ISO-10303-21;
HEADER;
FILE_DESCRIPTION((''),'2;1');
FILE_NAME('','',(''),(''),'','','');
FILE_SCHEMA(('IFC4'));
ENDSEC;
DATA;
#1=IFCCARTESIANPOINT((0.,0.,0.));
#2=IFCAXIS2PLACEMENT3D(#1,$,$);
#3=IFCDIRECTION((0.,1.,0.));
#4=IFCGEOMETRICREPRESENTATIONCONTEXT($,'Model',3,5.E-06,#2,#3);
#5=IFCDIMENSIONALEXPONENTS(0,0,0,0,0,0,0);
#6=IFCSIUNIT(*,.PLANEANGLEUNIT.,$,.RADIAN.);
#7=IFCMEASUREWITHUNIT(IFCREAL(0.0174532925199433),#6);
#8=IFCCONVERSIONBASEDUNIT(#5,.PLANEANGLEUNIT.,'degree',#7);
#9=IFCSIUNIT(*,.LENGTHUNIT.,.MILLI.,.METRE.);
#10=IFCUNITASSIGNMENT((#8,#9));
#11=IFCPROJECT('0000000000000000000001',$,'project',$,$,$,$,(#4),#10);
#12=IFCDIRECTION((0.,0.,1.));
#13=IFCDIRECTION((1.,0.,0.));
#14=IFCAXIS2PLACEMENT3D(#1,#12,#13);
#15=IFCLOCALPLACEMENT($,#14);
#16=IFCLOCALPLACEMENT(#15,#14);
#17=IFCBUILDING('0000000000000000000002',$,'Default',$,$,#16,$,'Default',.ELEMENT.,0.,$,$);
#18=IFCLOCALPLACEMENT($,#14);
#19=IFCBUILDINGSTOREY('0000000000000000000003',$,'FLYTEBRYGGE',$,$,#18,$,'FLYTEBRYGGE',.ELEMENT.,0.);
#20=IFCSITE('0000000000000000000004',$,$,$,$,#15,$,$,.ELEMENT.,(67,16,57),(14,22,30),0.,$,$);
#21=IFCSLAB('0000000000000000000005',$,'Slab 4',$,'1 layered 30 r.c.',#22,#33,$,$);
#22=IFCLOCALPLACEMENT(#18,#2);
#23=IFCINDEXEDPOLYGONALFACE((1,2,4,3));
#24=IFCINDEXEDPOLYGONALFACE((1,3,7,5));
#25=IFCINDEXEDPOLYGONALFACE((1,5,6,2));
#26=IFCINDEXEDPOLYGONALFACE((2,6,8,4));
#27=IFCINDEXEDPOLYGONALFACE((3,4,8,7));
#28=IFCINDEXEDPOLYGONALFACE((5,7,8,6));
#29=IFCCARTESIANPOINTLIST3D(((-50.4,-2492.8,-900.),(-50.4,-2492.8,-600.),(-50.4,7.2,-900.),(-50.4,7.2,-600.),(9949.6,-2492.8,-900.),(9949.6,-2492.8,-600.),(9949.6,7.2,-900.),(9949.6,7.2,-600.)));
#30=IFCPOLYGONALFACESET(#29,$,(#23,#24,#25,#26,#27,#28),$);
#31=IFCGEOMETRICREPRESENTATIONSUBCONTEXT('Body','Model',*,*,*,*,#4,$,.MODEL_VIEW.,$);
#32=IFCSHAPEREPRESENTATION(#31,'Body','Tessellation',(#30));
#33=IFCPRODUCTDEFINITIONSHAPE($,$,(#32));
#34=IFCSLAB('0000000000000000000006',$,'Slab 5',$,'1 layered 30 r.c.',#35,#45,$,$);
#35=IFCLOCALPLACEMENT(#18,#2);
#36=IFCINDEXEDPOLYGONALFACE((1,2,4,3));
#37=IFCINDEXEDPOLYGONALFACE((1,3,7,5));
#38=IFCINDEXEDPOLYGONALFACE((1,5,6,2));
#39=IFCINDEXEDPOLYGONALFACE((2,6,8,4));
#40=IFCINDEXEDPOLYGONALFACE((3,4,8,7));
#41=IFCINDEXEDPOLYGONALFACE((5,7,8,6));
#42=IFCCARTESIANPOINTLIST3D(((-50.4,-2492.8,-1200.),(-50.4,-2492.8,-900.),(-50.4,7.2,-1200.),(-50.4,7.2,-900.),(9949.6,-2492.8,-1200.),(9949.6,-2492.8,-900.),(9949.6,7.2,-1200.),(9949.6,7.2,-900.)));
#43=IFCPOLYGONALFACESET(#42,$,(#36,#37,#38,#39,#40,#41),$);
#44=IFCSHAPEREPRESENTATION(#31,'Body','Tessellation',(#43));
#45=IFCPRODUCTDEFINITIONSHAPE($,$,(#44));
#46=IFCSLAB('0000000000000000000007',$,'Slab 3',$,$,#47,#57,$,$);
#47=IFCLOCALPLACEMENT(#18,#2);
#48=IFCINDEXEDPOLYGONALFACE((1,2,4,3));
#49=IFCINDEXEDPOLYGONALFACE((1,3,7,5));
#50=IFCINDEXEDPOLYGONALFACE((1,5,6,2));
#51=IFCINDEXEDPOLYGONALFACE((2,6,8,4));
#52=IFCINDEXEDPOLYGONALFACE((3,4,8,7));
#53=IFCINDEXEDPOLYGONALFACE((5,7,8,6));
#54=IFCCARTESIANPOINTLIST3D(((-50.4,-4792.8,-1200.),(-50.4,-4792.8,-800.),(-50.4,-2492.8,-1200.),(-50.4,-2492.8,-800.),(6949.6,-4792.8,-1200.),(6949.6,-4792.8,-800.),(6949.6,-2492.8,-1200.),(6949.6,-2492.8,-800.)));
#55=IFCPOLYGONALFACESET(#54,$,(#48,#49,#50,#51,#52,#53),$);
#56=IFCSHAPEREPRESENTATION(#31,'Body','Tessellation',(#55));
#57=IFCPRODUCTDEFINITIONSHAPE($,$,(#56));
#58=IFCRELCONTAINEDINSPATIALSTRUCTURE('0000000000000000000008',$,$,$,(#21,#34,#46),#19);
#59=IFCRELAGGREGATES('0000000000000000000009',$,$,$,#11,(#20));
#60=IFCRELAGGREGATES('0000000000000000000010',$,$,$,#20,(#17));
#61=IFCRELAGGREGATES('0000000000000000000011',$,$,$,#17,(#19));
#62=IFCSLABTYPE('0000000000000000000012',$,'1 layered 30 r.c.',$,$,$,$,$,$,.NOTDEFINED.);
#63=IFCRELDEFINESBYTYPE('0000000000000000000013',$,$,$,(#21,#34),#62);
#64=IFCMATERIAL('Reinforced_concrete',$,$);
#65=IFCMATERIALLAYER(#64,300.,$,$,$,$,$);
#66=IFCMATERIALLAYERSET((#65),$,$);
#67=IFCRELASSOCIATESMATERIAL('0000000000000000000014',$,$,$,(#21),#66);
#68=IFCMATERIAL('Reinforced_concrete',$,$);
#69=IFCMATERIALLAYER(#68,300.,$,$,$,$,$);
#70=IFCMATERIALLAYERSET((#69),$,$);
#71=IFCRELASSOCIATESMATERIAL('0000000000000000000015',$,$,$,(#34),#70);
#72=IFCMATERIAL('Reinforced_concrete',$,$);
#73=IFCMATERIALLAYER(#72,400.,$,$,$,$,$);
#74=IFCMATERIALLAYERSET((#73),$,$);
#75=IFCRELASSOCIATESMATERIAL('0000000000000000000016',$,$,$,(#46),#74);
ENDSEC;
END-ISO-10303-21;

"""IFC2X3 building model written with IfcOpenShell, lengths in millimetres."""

from ifc_helpers import new_model, entity, si_unit, converted_unit, direction, frame, origin, origin_with_axes, place, context, subcontext, project, spatial, polyline, outline, extrude, material, layer, layer_set, layer_usage, type_object, element, save


model = new_model("IFC2X3")

# Units and contexts
model_context = context("Model", 3, precision=5e-06, world=origin(), true_north=direction((0.0, 1.0, 0.0)))
body_context = subcontext(model_context, "Body", "Model", "MODEL_VIEW")
ifc_project = project(units=[converted_unit("PLANEANGLEUNIT", "degree", entity("IfcReal", 0.0174532925199433), si_unit("PLANEANGLEUNIT", "RADIAN"), dimensions=[0, 0, 0, 0, 0, 0, 0]), si_unit("LENGTHUNIT", "METRE", prefix="MILLI")], contexts=[model_context])

# Site, building, storey
site_placement = place(None, origin_with_axes())
site = spatial("IfcSite", under=ifc_project, at=site_placement, CompositionType="ELEMENT", RefLatitude=(67, 16, 57), RefLongitude=(14, 22, 30), RefElevation=0.0)
building_placement = place(site_placement, origin_with_axes())
building = spatial("IfcBuilding", under=site, at=building_placement, Name="Default", LongName="Default", CompositionType="ELEMENT", ElevationOfRefHeight=0.0)
storey_placement = place(None, origin_with_axes())
storey = spatial("IfcBuildingStorey", under=building, at=storey_placement, Name="FLYTEBRYGGE", LongName="FLYTEBRYGGE", CompositionType="ELEMENT", Elevation=0.0)

# Slabs
ifc_material_1 = material(Name="Reinforced_concrete")
ifc_layer_1 = layer(ifc_material_1, 300.0)
ifc_layer_set_1 = layer_set([ifc_layer_1])
ifc_layer_usage_1 = layer_usage(ifc_layer_set_1, "AXIS3", "NEGATIVE", 0.0)
slab_type = type_object("IfcSlabType", Name="1 layered 30 r.c.", PredefinedType="NOTDEFINED")
slab_1_placement = place(storey_placement, frame((4949.6, -1242.8, -600.0), z_axis=(0.0, 0.0, 1.0), x_axis=(1.0, 0.0, 0.0)))
element("IfcSlab", 1, at=slab_1_placement, inside=storey, type_object=slab_type, material=ifc_layer_usage_1, Name="Slab 4", ObjectType="1 layered 30 r.c.", context=body_context, shape_type="SweptSolid", body=[
    extrude(outline(polyline([(-50.4, -2492.8), (9949.6, -2492.8), (9949.6, 7.2), (-50.4, 7.2), (-50.4, -2492.8)])), frame((-4949.6, 1242.8, -300.0), z_axis=(0.0, 0.0, 1.0), x_axis=(1.0, 0.0, 0.0)), (0.0, 0.0, 1.0), 300.0),
])
ifc_material_2 = material(Name="Reinforced_concrete")
ifc_layer_2 = layer(ifc_material_2, 300.0)
ifc_layer_set_2 = layer_set([ifc_layer_2])
ifc_layer_usage_2 = layer_usage(ifc_layer_set_2, "AXIS3", "NEGATIVE", 0.0)
slab_2_placement = place(storey_placement, frame((4949.6, -1242.8, -900.0), z_axis=(0.0, 0.0, 1.0), x_axis=(1.0, 0.0, 0.0)))
element("IfcSlab", 2, at=slab_2_placement, inside=storey, type_object=slab_type, material=ifc_layer_usage_2, Name="Slab 5", ObjectType="1 layered 30 r.c.", context=body_context, shape_type="SweptSolid", body=[
    extrude(outline(polyline([(-50.4, -2492.8), (9949.6, -2492.8), (9949.6, 7.2), (-50.4, 7.2), (-50.4, -2492.8)])), frame((-4949.6, 1242.8, -300.0), z_axis=(0.0, 0.0, 1.0), x_axis=(1.0, 0.0, 0.0)), (0.0, 0.0, 1.0), 300.0),
])
ifc_material_3 = material(Name="Reinforced_concrete")
ifc_layer_3 = layer(ifc_material_3, 400.0)
ifc_layer_set_3 = layer_set([ifc_layer_3])
ifc_layer_usage_3 = layer_usage(ifc_layer_set_3, "AXIS3", "NEGATIVE", 0.0)
slab_3_placement = place(storey_placement, frame((3449.6, -3642.8, -800.0), z_axis=(0.0, 0.0, 1.0), x_axis=(1.0, 0.0, 0.0)))
element("IfcSlab", 3, at=slab_3_placement, inside=storey, material=ifc_layer_usage_3, Name="Slab 3", context=body_context, shape_type="SweptSolid", body=[
    extrude(outline(polyline([(-50.4, -4792.8), (6949.6, -4792.8), (6949.6, -2492.8), (-50.4, -2492.8), (-50.4, -4792.8)])), frame((-3449.6, 3642.8, -400.0), z_axis=(0.0, 0.0, 1.0), x_axis=(1.0, 0.0, 0.0)), (0.0, 0.0, 1.0), 400.0),
])

save(model, "model.ifc")
